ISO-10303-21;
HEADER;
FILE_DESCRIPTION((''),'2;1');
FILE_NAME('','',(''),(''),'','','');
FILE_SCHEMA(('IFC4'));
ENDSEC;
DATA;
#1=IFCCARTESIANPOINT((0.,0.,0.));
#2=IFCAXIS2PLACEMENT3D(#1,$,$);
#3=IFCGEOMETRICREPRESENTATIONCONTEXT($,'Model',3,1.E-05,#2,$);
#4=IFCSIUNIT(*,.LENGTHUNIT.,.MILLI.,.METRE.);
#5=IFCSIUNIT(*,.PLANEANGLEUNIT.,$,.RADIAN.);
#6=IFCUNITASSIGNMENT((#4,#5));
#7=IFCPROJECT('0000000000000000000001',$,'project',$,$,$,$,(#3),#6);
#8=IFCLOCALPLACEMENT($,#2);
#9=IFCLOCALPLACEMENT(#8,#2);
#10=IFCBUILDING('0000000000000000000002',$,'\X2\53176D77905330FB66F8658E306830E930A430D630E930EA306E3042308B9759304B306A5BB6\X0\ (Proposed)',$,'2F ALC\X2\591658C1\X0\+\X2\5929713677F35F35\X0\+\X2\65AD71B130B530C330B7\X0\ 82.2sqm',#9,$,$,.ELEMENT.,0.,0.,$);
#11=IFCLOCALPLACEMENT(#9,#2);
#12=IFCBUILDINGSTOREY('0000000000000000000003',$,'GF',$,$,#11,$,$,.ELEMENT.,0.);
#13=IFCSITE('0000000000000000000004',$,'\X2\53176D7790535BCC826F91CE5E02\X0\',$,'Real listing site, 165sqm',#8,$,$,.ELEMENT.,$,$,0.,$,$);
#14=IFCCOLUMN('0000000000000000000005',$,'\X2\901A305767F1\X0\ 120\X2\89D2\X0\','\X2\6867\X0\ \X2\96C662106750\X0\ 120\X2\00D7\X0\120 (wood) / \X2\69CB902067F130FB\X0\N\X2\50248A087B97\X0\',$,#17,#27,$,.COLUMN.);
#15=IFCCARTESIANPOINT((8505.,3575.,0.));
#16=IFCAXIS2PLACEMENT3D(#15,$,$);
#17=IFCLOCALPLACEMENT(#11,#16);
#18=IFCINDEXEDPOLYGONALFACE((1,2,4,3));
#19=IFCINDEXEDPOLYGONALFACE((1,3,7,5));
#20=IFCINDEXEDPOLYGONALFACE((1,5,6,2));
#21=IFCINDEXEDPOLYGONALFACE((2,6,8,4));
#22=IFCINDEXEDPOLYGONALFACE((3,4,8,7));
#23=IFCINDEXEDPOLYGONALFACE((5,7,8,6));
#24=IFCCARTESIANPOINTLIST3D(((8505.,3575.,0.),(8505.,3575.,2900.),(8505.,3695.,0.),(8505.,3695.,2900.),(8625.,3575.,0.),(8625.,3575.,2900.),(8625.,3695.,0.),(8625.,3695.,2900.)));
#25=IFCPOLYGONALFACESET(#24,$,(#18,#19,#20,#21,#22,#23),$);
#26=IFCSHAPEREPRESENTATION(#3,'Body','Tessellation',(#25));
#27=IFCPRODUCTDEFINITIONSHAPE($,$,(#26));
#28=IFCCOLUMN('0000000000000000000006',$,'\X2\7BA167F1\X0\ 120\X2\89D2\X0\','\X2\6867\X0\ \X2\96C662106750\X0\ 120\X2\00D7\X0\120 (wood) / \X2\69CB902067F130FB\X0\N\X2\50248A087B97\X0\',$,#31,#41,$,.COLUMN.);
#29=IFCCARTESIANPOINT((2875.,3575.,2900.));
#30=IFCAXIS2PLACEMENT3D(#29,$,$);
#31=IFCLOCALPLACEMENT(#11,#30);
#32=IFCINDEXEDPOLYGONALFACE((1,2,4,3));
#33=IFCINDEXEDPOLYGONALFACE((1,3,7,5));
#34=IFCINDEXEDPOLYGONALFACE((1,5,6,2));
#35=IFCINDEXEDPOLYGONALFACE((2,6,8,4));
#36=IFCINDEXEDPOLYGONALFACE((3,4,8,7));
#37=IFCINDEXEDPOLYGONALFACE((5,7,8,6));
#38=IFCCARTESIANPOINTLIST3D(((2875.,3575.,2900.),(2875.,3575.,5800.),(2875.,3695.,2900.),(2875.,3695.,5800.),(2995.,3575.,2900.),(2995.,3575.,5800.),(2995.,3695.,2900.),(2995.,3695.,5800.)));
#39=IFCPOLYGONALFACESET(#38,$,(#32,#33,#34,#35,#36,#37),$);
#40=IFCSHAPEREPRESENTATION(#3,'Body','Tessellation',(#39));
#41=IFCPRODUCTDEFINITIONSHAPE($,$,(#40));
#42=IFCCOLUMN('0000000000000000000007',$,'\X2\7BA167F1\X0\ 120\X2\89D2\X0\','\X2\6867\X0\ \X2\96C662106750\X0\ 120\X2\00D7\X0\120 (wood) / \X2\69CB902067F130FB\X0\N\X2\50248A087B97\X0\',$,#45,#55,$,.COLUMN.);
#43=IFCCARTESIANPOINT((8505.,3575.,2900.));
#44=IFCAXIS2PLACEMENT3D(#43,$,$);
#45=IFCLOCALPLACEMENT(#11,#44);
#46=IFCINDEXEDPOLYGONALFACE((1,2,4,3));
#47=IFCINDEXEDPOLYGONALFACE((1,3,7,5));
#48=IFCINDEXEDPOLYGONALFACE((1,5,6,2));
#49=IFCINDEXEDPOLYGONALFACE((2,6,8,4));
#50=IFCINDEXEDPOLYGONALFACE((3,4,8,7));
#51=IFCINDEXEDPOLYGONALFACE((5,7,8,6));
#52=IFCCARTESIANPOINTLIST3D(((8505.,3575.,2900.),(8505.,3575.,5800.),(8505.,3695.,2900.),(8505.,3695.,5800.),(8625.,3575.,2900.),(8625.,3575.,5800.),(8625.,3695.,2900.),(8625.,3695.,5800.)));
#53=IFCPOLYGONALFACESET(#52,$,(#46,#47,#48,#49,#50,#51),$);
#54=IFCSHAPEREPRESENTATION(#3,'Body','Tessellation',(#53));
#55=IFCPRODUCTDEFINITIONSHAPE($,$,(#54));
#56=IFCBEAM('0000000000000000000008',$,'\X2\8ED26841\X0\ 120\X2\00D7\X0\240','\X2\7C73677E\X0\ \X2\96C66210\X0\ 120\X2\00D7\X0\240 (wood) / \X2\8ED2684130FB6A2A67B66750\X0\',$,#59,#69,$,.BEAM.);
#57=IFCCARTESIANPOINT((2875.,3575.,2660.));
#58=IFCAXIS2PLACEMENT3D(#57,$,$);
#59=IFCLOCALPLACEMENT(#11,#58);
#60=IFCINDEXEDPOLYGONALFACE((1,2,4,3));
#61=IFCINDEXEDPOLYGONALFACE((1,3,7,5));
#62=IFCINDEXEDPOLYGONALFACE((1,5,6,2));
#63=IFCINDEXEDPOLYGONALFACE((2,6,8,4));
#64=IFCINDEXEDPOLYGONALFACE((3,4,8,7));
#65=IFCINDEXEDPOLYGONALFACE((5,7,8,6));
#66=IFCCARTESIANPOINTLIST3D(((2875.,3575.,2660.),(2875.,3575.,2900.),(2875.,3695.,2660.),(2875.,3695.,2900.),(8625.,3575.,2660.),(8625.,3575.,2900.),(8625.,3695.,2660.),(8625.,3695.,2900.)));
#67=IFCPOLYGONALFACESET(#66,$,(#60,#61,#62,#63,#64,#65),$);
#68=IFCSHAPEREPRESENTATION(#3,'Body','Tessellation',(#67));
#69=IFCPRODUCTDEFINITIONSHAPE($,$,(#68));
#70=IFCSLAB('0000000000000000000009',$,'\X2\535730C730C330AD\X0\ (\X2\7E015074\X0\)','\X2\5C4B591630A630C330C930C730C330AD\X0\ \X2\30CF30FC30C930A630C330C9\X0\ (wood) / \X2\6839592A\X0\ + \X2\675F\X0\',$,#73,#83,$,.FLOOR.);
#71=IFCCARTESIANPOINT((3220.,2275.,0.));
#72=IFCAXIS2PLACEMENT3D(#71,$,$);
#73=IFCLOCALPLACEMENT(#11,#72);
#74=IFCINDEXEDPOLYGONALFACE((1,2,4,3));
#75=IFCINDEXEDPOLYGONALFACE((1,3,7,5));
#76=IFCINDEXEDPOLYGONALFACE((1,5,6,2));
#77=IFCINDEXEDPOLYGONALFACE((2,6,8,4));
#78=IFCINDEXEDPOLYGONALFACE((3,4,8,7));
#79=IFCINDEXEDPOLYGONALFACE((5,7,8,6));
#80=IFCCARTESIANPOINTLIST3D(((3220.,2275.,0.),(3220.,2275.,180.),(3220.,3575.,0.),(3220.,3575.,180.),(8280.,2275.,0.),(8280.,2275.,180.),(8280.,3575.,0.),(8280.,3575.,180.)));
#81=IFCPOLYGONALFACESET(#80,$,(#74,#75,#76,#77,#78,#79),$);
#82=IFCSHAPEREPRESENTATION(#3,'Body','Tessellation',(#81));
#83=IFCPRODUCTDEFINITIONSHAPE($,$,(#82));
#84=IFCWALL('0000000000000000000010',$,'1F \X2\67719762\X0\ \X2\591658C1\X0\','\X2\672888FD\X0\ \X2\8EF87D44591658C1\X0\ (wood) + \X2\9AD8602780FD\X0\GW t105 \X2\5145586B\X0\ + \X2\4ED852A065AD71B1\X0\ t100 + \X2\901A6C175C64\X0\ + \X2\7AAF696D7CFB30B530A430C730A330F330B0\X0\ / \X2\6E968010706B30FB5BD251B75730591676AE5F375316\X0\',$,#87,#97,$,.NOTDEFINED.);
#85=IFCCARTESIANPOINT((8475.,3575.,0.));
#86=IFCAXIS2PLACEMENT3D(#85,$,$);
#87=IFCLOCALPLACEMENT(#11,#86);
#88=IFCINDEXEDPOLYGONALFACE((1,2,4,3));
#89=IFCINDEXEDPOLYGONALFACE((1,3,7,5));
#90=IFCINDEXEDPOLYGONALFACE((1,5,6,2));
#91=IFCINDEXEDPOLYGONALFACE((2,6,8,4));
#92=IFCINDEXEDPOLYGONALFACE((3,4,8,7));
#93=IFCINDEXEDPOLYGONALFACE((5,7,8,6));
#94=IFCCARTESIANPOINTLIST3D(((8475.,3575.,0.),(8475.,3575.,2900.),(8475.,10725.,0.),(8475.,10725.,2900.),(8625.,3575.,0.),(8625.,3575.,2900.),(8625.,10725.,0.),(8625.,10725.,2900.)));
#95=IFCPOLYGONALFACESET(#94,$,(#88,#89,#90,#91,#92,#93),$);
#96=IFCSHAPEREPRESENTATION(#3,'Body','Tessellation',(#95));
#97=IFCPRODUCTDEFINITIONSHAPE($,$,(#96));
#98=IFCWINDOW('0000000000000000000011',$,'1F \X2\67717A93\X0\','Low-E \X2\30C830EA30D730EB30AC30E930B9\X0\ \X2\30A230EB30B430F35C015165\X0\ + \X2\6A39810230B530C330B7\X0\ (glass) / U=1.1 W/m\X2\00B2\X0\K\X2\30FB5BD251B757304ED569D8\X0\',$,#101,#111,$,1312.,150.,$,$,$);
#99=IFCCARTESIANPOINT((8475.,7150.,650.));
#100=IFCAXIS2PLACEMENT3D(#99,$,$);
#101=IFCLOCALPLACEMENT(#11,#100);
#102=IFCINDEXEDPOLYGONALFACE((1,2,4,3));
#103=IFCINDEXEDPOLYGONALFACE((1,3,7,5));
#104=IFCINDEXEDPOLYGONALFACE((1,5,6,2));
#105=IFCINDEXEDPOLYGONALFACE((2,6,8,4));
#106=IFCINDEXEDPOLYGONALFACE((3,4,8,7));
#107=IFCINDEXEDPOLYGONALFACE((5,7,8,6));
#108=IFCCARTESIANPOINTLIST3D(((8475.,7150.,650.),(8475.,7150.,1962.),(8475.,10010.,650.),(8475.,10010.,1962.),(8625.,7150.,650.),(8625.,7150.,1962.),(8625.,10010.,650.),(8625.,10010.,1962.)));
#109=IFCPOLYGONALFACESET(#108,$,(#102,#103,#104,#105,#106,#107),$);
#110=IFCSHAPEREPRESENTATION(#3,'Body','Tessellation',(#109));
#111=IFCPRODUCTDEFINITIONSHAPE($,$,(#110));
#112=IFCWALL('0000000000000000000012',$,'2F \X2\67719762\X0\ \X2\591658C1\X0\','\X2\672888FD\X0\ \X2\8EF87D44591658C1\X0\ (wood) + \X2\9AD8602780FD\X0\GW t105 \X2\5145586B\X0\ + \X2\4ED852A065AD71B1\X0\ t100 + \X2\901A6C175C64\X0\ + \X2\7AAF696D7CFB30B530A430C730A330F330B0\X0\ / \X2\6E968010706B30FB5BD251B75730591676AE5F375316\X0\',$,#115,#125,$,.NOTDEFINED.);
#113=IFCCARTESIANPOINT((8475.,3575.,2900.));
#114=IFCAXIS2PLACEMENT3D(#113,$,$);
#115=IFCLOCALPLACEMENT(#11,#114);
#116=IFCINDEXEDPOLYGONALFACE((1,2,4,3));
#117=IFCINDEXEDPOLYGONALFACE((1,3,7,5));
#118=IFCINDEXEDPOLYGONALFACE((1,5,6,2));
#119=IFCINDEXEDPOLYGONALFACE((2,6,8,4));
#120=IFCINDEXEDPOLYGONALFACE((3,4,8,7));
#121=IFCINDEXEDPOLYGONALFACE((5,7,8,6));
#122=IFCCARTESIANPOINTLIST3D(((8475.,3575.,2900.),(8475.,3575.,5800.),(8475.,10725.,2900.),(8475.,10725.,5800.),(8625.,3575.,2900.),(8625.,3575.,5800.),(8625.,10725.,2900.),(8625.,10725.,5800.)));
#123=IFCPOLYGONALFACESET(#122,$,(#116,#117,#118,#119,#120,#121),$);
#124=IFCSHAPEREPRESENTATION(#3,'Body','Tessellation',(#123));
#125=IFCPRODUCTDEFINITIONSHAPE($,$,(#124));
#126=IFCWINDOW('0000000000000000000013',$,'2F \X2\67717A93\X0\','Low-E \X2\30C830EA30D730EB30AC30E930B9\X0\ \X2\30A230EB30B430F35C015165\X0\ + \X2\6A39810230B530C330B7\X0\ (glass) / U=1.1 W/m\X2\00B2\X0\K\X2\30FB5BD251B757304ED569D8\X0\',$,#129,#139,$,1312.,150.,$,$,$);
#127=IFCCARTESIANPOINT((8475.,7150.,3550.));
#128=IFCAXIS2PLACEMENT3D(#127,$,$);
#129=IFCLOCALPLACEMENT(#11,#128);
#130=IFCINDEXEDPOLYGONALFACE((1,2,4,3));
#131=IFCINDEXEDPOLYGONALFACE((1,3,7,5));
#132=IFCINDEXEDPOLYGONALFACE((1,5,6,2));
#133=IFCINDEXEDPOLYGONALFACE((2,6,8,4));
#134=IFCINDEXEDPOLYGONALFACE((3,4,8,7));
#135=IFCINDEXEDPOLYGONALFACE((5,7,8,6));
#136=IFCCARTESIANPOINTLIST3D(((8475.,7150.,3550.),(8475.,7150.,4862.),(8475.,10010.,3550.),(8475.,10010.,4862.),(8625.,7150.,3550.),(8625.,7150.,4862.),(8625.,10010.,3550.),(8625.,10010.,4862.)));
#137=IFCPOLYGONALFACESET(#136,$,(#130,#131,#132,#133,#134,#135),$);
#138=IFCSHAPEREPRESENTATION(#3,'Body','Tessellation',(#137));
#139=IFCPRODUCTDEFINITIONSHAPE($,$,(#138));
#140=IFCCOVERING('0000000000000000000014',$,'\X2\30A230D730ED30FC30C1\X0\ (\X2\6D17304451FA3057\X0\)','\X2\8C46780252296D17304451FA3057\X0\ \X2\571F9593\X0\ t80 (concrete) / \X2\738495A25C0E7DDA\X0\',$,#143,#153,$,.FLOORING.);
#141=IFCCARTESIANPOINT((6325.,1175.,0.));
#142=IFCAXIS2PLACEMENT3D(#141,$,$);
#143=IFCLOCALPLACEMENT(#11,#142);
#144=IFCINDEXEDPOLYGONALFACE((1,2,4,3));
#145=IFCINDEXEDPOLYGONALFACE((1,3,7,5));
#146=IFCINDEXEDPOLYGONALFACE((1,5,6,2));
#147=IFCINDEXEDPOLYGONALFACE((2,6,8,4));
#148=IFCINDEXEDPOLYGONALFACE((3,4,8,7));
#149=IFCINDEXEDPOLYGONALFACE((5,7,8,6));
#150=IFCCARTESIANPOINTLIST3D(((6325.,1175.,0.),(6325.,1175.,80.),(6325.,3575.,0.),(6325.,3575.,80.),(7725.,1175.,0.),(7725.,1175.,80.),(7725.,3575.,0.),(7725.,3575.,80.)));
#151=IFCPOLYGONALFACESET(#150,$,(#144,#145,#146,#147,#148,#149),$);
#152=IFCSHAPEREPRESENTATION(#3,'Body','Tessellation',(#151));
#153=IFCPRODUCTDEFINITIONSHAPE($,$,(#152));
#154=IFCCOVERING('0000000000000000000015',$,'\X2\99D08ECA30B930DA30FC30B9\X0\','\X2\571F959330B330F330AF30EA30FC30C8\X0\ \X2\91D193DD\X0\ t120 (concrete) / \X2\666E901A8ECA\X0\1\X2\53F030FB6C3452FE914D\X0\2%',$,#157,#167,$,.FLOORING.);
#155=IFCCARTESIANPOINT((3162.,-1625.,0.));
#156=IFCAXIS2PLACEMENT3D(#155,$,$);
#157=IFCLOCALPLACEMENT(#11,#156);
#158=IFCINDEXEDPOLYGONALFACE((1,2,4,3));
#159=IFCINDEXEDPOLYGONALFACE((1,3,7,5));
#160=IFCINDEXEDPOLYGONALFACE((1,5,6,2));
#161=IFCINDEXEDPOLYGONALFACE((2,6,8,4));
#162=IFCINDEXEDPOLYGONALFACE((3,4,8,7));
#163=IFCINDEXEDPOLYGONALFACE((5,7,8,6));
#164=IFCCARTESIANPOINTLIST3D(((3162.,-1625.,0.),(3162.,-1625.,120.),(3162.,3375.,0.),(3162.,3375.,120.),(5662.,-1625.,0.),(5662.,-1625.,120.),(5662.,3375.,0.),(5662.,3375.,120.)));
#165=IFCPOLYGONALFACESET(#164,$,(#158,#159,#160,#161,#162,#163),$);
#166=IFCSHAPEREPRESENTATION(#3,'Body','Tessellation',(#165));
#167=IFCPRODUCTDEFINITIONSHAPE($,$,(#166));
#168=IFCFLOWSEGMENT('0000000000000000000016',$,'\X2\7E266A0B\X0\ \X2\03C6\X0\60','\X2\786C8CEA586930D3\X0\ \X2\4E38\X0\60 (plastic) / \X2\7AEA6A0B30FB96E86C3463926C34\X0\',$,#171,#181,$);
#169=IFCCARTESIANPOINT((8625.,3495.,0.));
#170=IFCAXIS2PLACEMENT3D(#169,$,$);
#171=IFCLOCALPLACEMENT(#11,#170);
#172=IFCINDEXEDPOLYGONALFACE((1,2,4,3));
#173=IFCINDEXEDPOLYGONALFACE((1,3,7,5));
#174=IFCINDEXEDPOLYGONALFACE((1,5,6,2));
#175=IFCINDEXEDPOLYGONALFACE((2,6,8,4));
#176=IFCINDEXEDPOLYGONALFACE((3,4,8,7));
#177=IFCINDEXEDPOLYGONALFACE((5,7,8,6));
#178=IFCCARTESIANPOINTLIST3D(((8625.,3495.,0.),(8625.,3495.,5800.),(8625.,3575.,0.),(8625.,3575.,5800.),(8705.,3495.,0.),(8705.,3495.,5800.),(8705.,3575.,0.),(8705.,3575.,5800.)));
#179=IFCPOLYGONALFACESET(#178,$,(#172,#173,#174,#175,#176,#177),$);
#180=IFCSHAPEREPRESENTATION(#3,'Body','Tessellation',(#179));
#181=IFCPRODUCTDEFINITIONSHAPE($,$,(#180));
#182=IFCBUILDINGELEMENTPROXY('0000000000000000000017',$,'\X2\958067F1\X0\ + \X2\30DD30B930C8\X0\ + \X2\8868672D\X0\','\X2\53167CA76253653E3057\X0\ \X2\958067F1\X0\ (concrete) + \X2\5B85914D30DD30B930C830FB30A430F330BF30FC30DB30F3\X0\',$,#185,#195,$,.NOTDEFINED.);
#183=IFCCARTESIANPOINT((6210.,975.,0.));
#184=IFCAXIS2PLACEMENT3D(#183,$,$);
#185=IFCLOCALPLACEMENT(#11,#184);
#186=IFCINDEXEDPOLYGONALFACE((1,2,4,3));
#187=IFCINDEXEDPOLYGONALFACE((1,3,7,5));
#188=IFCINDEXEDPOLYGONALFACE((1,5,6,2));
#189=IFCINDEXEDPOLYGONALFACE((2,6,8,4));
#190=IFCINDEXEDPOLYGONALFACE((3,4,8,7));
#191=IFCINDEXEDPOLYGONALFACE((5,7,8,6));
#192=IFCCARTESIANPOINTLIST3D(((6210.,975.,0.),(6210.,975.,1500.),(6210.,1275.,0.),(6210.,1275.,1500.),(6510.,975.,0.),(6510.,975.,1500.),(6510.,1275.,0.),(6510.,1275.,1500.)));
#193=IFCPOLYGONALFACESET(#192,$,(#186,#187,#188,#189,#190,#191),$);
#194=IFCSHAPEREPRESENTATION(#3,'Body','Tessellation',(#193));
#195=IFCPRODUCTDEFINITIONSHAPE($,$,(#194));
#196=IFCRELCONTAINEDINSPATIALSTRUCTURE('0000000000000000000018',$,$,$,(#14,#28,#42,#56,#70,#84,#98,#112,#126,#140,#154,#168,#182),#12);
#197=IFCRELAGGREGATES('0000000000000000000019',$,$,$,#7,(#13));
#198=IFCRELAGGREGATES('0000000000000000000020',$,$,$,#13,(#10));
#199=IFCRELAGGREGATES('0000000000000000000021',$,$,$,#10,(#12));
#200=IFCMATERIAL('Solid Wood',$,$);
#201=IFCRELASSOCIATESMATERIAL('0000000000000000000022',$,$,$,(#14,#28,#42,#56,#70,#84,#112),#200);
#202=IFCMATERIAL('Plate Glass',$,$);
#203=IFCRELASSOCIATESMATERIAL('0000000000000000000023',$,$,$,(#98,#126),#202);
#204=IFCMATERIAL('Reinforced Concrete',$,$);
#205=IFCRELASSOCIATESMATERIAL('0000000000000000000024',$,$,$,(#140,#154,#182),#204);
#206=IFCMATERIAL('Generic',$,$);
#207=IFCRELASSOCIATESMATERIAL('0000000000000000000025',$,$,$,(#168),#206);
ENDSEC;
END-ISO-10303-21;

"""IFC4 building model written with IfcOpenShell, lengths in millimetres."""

from ifc_helpers import new_model, si_unit, frame, frame_2d, origin, place, context, project, spatial, rectangle, extrude, material, element, fill, save


model = new_model("IFC4")

# Units and contexts
model_context = context("Model", 3, precision=1e-05, world=origin())
ifc_project = project(units=[si_unit("LENGTHUNIT", "METRE", prefix="MILLI"), si_unit("PLANEANGLEUNIT", "RADIAN")], contexts=[model_context])

# Site, building, storey
site_placement = place(None, origin())
site = spatial("IfcSite", under=ifc_project, at=site_placement, Name="北海道富良野市", ObjectType="Real listing site, 165sqm", CompositionType="ELEMENT", RefElevation=0.0)
building_placement = place(site_placement, origin())
building = spatial("IfcBuilding", under=site, at=building_placement, Name="北海道・書斎とライブラリのある静かな家 (Proposed)", ObjectType="2F ALC外壁+天然石張+断熱サッシ 82.2sqm", CompositionType="ELEMENT", ElevationOfRefHeight=0.0, ElevationOfTerrain=0.0)
storey_placement = place(building_placement, origin())
storey = spatial("IfcBuildingStorey", under=building, at=storey_placement, Name="GF", CompositionType="ELEMENT", Elevation=0.0)

# Columns
ifc_material_1 = material(Name="Solid Wood")
column_1_placement = place(storey_placement, frame((8505.0, 3575.0, 0.0)))
element("IfcColumn", 1, at=column_1_placement, inside=storey, material=ifc_material_1, Name="通し柱 120角", Description="桧 集成材 120×120 (wood) / 構造柱・N値計算", PredefinedType="COLUMN", context=model_context, shape_type="SweptSolid", body=[
    extrude(rectangle(XDim=120.0, YDim=120.0, at=frame_2d((60.0, 60.0))), frame((8505.0, 3575.0, 0.0)), (0.0, 0.0, 1.0), 2900.0),
])
column_2_placement = place(storey_placement, frame((2875.0, 3575.0, 2900.0)))
element("IfcColumn", 2, at=column_2_placement, inside=storey, material=ifc_material_1, Name="管柱 120角", Description="桧 集成材 120×120 (wood) / 構造柱・N値計算", PredefinedType="COLUMN", context=model_context, shape_type="SweptSolid", body=[
    extrude(rectangle(XDim=120.0, YDim=120.0, at=frame_2d((60.0, 60.0))), frame((2875.0, 3575.0, 2900.0)), (0.0, 0.0, 1.0), 2900.0),
])
column_3_placement = place(storey_placement, frame((8505.0, 3575.0, 2900.0)))
element("IfcColumn", 3, at=column_3_placement, inside=storey, material=ifc_material_1, Name="管柱 120角", Description="桧 集成材 120×120 (wood) / 構造柱・N値計算", PredefinedType="COLUMN", context=model_context, shape_type="SweptSolid", body=[
    extrude(rectangle(XDim=120.0, YDim=120.0, at=frame_2d((60.0, 60.0))), frame((8505.0, 3575.0, 2900.0)), (0.0, 0.0, 1.0), 2900.0),
])

# Beam
beam_1_placement = place(storey_placement, frame((2875.0, 3575.0, 2660.0)))
element("IfcBeam", 4, at=beam_1_placement, inside=storey, material=ifc_material_1, Name="軒桁 120×240", Description="米松 集成 120×240 (wood) / 軒桁・横架材", PredefinedType="BEAM", context=model_context, shape_type="SweptSolid", body=[
    extrude(rectangle(XDim=5750.0, YDim=120.0, at=frame_2d((2875.0, 60.0))), frame((2875.0, 3575.0, 2660.0)), (0.0, 0.0, 1.0), 240.0),
])

# Slab
slab_placement = place(storey_placement, frame((3220.0, 2275.0, 0.0)))
element("IfcSlab", 5, at=slab_placement, inside=storey, material=ifc_material_1, Name="南デッキ (縁側)", Description="屋外ウッドデッキ ハードウッド (wood) / 根太 + 束", PredefinedType="FLOOR", context=model_context, shape_type="SweptSolid", body=[
    extrude(rectangle(XDim=5060.0, YDim=1300.0, at=frame_2d((2530.0, 650.0))), frame((3220.0, 2275.0, 0.0)), (0.0, 0.0, 1.0), 180.0),
])

# Walls, openings, windows
wall_1_placement = place(storey_placement, frame((8475.0, 3575.0, 0.0)))
wall_1 = element("IfcWall", 6, at=wall_1_placement, inside=storey, material=ifc_material_1, Name="1F 東面 外壁", Description="木製 軸組外壁 (wood) + 高性能GW t105 充填 + 付加断熱 t100 + 通気層 + 窯業系サイディング / 準耐火・寒冷地外皮強化", PredefinedType="NOTDEFINED", context=model_context, shape_type="SweptSolid", body=[
    extrude(rectangle(XDim=150.0, YDim=7150.0, at=frame_2d((75.0, 3575.0))), frame((8475.0, 3575.0, 0.0)), (0.0, 0.0, 1.0), 2900.0),
])
opening_1_placement = place(storey_placement, frame((8475.0, 7150.0, 650.0)))
opening_1 = element("IfcOpeningElement", 7, at=opening_1_placement, cuts=wall_1, PredefinedType="NOTDEFINED", context=model_context, shape_type="SweptSolid", body=[
    extrude(rectangle(XDim=150.0, YDim=2860.0, at=frame_2d((75.0, 1430.0))), frame((8475.0, 7150.0, 650.0)), (0.0, 0.0, 1.0), 1312.0),
])
ifc_material_2 = material(Name="Plate Glass")
window_1_placement = place(storey_placement, frame((8475.0, 7150.0, 650.0)))
window_1 = element("IfcWindow", 8, at=window_1_placement, inside=storey, material=ifc_material_2, Name="1F 東窓", Description="Low-E トリプルガラス アルゴン封入 + 樹脂サッシ (glass) / U=1.1 W/m²K・寒冷地仕様", OverallHeight=1312.0, OverallWidth=150.0, context=model_context, shape_type="SweptSolid", body=[
    extrude(rectangle(XDim=150.0, YDim=2860.0, at=frame_2d((75.0, 1430.0))), frame((8475.0, 7150.0, 650.0)), (0.0, 0.0, 1.0), 1312.0),
])
fill(opening_1, window_1)
wall_2_placement = place(storey_placement, frame((8475.0, 3575.0, 2900.0)))
wall_2 = element("IfcWall", 9, at=wall_2_placement, inside=storey, material=ifc_material_1, Name="2F 東面 外壁", Description="木製 軸組外壁 (wood) + 高性能GW t105 充填 + 付加断熱 t100 + 通気層 + 窯業系サイディング / 準耐火・寒冷地外皮強化", PredefinedType="NOTDEFINED", context=model_context, shape_type="SweptSolid", body=[
    extrude(rectangle(XDim=150.0, YDim=7150.0, at=frame_2d((75.0, 3575.0))), frame((8475.0, 3575.0, 2900.0)), (0.0, 0.0, 1.0), 2900.0),
])
opening_2_placement = place(storey_placement, frame((8475.0, 7150.0, 3550.0)))
opening_2 = element("IfcOpeningElement", 10, at=opening_2_placement, cuts=wall_2, PredefinedType="NOTDEFINED", context=model_context, shape_type="SweptSolid", body=[
    extrude(rectangle(XDim=150.0, YDim=2860.0, at=frame_2d((75.0, 1430.0))), frame((8475.0, 7150.0, 3550.0)), (0.0, 0.0, 1.0), 1312.0),
])
window_2_placement = place(storey_placement, frame((8475.0, 7150.0, 3550.0)))
window_2 = element("IfcWindow", 11, at=window_2_placement, inside=storey, material=ifc_material_2, Name="2F 東窓", Description="Low-E トリプルガラス アルゴン封入 + 樹脂サッシ (glass) / U=1.1 W/m²K・寒冷地仕様", OverallHeight=1312.0, OverallWidth=150.0, context=model_context, shape_type="SweptSolid", body=[
    extrude(rectangle(XDim=150.0, YDim=2860.0, at=frame_2d((75.0, 1430.0))), frame((8475.0, 7150.0, 3550.0)), (0.0, 0.0, 1.0), 1312.0),
])
fill(opening_2, window_2)

# Coverings
ifc_material_3 = material(Name="Reinforced Concrete")
covering_1_placement = place(storey_placement, frame((6325.0, 1175.0, 0.0)))
element("IfcCovering", 12, at=covering_1_placement, inside=storey, material=ifc_material_3, Name="アプローチ (洗い出し)", Description="豆砂利洗い出し 土間 t80 (concrete) / 玄関導線", PredefinedType="FLOORING", context=model_context, shape_type="SweptSolid", body=[
    extrude(rectangle(XDim=1400.0, YDim=2400.0, at=frame_2d((700.0, 1200.0))), frame((6325.0, 1175.0, 0.0)), (0.0, 0.0, 1.0), 80.0),
])
covering_2_placement = place(storey_placement, frame((3162.0, -1625.0, 0.0)))
element("IfcCovering", 13, at=covering_2_placement, inside=storey, material=ifc_material_3, Name="駐車スペース", Description="土間コンクリート 金鏝 t120 (concrete) / 普通車1台・水勾配2%", PredefinedType="FLOORING", context=model_context, shape_type="SweptSolid", body=[
    extrude(rectangle(XDim=2500.0, YDim=5000.0, at=frame_2d((1250.0, 2500.0))), frame((3162.0, -1625.0, 0.0)), (0.0, 0.0, 1.0), 120.0),
])

# Flow segment
ifc_material_4 = material(Name="Generic")
flow_segment_placement = place(storey_placement, frame((8625.0, 3495.0, 0.0)))
element("IfcFlowSegment", 14, at=flow_segment_placement, inside=storey, material=ifc_material_4, Name="縦樋 φ60", Description="硬質塩ビ 丸60 (plastic) / 竪樋・雨水排水", context=model_context, shape_type="SweptSolid", body=[
    extrude(rectangle(XDim=80.0, YDim=80.0, at=frame_2d((40.0, 40.0))), frame((8625.0, 3495.0, 0.0)), (0.0, 0.0, 1.0), 5800.0),
])

# Building element proxy
proxy_placement = place(storey_placement, frame((6210.0, 975.0, 0.0)))
element("IfcBuildingElementProxy", 15, at=proxy_placement, inside=storey, material=ifc_material_3, Name="門柱 + ポスト + 表札", Description="化粧打放し 門柱 (concrete) + 宅配ポスト・インターホン", PredefinedType="NOTDEFINED", context=model_context, shape_type="SweptSolid", body=[
    extrude(rectangle(XDim=300.0, YDim=300.0, at=frame_2d((150.0, 150.0))), frame((6210.0, 975.0, 0.0)), (0.0, 0.0, 1.0), 1500.0),
])

save(model, "model.ifc")
